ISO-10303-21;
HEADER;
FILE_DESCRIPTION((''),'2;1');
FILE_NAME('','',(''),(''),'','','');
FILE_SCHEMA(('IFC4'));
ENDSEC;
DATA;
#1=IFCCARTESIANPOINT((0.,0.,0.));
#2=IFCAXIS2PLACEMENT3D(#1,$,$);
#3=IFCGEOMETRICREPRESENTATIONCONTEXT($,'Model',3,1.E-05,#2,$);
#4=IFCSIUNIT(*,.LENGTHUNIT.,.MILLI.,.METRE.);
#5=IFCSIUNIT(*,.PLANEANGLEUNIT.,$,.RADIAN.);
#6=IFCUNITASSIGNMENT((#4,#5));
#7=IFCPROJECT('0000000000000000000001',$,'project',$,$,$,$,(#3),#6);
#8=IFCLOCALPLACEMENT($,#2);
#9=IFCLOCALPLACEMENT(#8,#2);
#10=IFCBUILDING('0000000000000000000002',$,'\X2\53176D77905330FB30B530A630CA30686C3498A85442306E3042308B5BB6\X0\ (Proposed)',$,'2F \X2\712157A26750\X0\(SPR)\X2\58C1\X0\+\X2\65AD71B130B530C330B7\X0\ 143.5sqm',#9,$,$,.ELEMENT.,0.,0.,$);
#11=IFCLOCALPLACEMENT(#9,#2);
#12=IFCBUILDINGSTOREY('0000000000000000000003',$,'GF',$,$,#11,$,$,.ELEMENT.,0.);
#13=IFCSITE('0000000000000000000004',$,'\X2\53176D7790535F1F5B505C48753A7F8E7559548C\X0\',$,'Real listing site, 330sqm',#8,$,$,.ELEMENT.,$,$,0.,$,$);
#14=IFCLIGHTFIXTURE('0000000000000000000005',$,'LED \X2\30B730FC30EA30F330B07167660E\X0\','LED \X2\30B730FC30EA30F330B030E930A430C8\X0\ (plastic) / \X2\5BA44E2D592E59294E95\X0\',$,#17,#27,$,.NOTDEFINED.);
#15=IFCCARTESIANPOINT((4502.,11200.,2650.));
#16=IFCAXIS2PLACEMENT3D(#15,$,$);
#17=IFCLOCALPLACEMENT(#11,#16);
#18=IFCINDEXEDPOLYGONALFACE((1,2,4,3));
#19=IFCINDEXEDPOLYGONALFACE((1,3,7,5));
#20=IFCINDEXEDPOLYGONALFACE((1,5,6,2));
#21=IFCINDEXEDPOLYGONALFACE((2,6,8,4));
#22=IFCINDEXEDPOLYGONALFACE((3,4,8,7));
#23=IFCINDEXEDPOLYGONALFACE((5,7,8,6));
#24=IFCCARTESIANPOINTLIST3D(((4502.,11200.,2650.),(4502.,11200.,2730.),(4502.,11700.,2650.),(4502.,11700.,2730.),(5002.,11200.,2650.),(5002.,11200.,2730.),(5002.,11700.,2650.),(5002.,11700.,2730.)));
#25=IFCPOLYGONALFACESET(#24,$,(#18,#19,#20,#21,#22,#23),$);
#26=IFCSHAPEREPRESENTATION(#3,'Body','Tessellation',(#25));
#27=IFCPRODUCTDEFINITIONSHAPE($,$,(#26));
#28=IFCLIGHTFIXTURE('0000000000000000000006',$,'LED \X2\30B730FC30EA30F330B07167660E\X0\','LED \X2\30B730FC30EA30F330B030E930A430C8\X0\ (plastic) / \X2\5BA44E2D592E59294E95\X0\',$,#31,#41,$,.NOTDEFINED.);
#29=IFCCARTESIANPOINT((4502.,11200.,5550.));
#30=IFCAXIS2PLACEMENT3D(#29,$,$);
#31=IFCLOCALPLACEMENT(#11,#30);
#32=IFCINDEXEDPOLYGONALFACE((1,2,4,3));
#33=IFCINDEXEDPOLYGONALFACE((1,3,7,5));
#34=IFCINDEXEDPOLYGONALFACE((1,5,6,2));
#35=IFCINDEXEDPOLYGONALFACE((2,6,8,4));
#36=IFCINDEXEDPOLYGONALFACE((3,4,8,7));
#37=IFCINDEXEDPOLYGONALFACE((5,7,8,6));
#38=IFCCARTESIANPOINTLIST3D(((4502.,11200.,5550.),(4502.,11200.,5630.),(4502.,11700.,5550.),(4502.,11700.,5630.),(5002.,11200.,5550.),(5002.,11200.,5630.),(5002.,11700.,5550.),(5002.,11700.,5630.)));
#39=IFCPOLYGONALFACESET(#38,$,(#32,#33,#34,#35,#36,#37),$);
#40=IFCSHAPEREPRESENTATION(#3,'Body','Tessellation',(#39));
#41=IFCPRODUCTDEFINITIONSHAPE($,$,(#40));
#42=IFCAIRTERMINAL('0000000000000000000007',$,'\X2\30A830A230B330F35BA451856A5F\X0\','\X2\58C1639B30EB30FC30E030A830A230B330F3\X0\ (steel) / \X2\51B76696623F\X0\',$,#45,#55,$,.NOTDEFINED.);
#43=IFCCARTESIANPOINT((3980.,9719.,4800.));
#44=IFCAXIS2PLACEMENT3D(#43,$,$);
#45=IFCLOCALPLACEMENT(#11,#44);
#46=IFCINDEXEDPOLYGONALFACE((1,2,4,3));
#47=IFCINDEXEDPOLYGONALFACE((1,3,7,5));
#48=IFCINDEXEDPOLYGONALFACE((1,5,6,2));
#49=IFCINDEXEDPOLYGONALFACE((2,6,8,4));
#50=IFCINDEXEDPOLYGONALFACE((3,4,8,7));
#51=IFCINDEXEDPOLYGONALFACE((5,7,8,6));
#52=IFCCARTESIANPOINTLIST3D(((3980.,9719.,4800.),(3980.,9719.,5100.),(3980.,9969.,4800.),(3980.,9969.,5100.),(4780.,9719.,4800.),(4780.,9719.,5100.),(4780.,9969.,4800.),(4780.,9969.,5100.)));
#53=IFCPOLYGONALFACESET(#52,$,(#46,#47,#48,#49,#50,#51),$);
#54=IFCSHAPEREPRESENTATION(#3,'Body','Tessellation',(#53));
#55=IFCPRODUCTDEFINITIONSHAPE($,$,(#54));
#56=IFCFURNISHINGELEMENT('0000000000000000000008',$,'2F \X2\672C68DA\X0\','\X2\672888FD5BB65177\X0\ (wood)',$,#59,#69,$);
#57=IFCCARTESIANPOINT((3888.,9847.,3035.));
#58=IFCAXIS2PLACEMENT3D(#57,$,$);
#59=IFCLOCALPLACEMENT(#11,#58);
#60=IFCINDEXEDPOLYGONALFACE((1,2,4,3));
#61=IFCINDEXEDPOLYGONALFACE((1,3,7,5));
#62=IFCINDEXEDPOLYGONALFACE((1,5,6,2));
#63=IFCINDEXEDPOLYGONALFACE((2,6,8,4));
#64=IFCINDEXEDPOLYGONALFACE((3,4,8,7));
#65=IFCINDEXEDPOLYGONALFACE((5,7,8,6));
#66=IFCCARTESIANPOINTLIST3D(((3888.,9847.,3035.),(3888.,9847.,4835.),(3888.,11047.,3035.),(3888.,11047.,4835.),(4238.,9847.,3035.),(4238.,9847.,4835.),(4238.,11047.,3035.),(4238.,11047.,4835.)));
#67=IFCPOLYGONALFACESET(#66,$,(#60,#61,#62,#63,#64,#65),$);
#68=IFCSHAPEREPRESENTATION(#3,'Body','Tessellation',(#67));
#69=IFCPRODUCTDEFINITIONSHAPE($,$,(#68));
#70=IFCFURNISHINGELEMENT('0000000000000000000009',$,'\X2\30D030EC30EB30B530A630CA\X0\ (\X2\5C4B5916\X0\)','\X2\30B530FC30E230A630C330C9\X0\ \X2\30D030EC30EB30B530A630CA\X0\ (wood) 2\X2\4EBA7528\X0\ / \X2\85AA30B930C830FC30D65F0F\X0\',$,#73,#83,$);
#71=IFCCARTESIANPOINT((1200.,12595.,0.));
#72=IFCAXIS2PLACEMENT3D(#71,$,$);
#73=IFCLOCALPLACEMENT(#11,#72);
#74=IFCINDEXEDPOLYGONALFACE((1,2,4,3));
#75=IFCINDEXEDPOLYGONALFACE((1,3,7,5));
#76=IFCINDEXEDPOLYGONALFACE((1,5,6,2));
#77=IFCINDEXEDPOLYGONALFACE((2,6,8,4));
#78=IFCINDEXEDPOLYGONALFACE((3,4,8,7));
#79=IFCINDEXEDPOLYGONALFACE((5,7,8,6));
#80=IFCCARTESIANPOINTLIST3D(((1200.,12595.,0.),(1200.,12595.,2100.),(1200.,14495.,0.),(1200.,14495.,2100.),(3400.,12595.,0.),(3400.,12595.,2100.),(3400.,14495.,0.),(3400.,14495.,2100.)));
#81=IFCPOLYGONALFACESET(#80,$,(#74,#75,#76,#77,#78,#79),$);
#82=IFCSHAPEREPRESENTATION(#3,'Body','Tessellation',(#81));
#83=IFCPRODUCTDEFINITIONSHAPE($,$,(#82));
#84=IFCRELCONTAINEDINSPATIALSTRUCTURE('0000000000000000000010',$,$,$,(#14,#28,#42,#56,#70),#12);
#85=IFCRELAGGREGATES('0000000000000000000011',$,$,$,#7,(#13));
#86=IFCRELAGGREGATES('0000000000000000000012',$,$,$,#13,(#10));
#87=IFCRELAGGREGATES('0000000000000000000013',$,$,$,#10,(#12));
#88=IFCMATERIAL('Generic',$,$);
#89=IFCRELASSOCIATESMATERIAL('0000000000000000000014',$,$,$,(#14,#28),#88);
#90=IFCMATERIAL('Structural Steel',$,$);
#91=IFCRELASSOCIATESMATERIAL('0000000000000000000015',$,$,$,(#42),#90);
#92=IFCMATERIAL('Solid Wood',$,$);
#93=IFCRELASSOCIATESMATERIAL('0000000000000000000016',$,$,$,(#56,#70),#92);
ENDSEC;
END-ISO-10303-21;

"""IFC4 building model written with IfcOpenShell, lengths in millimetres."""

from ifc_helpers import new_model, si_unit, frame, frame_2d, origin, place, context, project, spatial, rectangle, extrude, material, element, save


model = new_model("IFC4")

# Units and contexts
model_context = context("Model", 3, precision=1e-05, world=origin())
ifc_project = project(units=[si_unit("LENGTHUNIT", "METRE", prefix="MILLI"), si_unit("PLANEANGLEUNIT", "RADIAN")], contexts=[model_context])

# Site, building, storey
site_placement = place(None, origin())
site = spatial("IfcSite", under=ifc_project, at=site_placement, Name="北海道弟子屈町美留和", ObjectType="Real listing site, 330sqm", CompositionType="ELEMENT", RefElevation=0.0)
building_placement = place(site_placement, origin())
building = spatial("IfcBuilding", under=site, at=building_placement, Name="北海道・サウナと水風呂のある家 (Proposed)", ObjectType="2F 無垢材(SPR)壁+断熱サッシ 143.5sqm", CompositionType="ELEMENT", ElevationOfRefHeight=0.0, ElevationOfTerrain=0.0)
storey_placement = place(building_placement, origin())
storey = spatial("IfcBuildingStorey", under=building, at=storey_placement, Name="GF", CompositionType="ELEMENT", Elevation=0.0)

# Shared definitions
ifc_material_1 = material(Name="Solid Wood")

# Shared definitions
ifc_material_2 = material(Name="Structural Steel")

# Shared definitions
ifc_material_3 = material(Name="Generic")

# Light fixtures
light_fixture_1_placement = place(storey_placement, frame((4502.0, 11200.0, 2650.0)))
element("IfcLightFixture", 1, at=light_fixture_1_placement, inside=storey, material=ifc_material_3, Name="LED シーリング照明", Description="LED シーリングライト (plastic) / 室中央天井", PredefinedType="NOTDEFINED", context=model_context, shape_type="SweptSolid", body=[
    extrude(rectangle(XDim=500.0, YDim=500.0, at=frame_2d((250.0, 250.0))), frame((4502.0, 11200.0, 2650.0)), (0.0, 0.0, 1.0), 80.0),
])
light_fixture_2_placement = place(storey_placement, frame((4502.0, 11200.0, 5550.0)))
element("IfcLightFixture", 2, at=light_fixture_2_placement, inside=storey, material=ifc_material_3, Name="LED シーリング照明", Description="LED シーリングライト (plastic) / 室中央天井", PredefinedType="NOTDEFINED", context=model_context, shape_type="SweptSolid", body=[
    extrude(rectangle(XDim=500.0, YDim=500.0, at=frame_2d((250.0, 250.0))), frame((4502.0, 11200.0, 5550.0)), (0.0, 0.0, 1.0), 80.0),
])

# Air terminal
air_terminal_placement = place(storey_placement, frame((3980.0, 9719.0, 4800.0)))
element("IfcAirTerminal", 3, at=air_terminal_placement, inside=storey, material=ifc_material_2, Name="エアコン室内機", Description="壁掛ルームエアコン (steel) / 冷暖房", PredefinedType="NOTDEFINED", context=model_context, shape_type="SweptSolid", body=[
    extrude(rectangle(XDim=800.0, YDim=250.0, at=frame_2d((400.0, 125.0))), frame((3980.0, 9719.0, 4800.0)), (0.0, 0.0, 1.0), 300.0),
])

# Furnishing elements
furnishing_1_placement = place(storey_placement, frame((3888.0, 9847.0, 3035.0)))
element("IfcFurnishingElement", 4, at=furnishing_1_placement, inside=storey, material=ifc_material_1, Name="2F 本棚", Description="木製家具 (wood)", context=model_context, shape_type="SweptSolid", body=[
    extrude(rectangle(XDim=350.0, YDim=1200.0, at=frame_2d((175.0, 600.0))), frame((3888.0, 9847.0, 3035.0)), (0.0, 0.0, 1.0), 1800.0),
])
furnishing_2_placement = place(storey_placement, frame((1200.0, 12595.0, 0.0)))
element("IfcFurnishingElement", 5, at=furnishing_2_placement, inside=storey, material=ifc_material_1, Name="バレルサウナ (屋外)", Description="サーモウッド バレルサウナ (wood) 2人用 / 薪ストーブ式", context=model_context, shape_type="SweptSolid", body=[
    extrude(rectangle(XDim=2200.0, YDim=1900.0, at=frame_2d((1100.0, 950.0))), frame((1200.0, 12595.0, 0.0)), (0.0, 0.0, 1.0), 2100.0),
])

save(model, "model.ifc")
